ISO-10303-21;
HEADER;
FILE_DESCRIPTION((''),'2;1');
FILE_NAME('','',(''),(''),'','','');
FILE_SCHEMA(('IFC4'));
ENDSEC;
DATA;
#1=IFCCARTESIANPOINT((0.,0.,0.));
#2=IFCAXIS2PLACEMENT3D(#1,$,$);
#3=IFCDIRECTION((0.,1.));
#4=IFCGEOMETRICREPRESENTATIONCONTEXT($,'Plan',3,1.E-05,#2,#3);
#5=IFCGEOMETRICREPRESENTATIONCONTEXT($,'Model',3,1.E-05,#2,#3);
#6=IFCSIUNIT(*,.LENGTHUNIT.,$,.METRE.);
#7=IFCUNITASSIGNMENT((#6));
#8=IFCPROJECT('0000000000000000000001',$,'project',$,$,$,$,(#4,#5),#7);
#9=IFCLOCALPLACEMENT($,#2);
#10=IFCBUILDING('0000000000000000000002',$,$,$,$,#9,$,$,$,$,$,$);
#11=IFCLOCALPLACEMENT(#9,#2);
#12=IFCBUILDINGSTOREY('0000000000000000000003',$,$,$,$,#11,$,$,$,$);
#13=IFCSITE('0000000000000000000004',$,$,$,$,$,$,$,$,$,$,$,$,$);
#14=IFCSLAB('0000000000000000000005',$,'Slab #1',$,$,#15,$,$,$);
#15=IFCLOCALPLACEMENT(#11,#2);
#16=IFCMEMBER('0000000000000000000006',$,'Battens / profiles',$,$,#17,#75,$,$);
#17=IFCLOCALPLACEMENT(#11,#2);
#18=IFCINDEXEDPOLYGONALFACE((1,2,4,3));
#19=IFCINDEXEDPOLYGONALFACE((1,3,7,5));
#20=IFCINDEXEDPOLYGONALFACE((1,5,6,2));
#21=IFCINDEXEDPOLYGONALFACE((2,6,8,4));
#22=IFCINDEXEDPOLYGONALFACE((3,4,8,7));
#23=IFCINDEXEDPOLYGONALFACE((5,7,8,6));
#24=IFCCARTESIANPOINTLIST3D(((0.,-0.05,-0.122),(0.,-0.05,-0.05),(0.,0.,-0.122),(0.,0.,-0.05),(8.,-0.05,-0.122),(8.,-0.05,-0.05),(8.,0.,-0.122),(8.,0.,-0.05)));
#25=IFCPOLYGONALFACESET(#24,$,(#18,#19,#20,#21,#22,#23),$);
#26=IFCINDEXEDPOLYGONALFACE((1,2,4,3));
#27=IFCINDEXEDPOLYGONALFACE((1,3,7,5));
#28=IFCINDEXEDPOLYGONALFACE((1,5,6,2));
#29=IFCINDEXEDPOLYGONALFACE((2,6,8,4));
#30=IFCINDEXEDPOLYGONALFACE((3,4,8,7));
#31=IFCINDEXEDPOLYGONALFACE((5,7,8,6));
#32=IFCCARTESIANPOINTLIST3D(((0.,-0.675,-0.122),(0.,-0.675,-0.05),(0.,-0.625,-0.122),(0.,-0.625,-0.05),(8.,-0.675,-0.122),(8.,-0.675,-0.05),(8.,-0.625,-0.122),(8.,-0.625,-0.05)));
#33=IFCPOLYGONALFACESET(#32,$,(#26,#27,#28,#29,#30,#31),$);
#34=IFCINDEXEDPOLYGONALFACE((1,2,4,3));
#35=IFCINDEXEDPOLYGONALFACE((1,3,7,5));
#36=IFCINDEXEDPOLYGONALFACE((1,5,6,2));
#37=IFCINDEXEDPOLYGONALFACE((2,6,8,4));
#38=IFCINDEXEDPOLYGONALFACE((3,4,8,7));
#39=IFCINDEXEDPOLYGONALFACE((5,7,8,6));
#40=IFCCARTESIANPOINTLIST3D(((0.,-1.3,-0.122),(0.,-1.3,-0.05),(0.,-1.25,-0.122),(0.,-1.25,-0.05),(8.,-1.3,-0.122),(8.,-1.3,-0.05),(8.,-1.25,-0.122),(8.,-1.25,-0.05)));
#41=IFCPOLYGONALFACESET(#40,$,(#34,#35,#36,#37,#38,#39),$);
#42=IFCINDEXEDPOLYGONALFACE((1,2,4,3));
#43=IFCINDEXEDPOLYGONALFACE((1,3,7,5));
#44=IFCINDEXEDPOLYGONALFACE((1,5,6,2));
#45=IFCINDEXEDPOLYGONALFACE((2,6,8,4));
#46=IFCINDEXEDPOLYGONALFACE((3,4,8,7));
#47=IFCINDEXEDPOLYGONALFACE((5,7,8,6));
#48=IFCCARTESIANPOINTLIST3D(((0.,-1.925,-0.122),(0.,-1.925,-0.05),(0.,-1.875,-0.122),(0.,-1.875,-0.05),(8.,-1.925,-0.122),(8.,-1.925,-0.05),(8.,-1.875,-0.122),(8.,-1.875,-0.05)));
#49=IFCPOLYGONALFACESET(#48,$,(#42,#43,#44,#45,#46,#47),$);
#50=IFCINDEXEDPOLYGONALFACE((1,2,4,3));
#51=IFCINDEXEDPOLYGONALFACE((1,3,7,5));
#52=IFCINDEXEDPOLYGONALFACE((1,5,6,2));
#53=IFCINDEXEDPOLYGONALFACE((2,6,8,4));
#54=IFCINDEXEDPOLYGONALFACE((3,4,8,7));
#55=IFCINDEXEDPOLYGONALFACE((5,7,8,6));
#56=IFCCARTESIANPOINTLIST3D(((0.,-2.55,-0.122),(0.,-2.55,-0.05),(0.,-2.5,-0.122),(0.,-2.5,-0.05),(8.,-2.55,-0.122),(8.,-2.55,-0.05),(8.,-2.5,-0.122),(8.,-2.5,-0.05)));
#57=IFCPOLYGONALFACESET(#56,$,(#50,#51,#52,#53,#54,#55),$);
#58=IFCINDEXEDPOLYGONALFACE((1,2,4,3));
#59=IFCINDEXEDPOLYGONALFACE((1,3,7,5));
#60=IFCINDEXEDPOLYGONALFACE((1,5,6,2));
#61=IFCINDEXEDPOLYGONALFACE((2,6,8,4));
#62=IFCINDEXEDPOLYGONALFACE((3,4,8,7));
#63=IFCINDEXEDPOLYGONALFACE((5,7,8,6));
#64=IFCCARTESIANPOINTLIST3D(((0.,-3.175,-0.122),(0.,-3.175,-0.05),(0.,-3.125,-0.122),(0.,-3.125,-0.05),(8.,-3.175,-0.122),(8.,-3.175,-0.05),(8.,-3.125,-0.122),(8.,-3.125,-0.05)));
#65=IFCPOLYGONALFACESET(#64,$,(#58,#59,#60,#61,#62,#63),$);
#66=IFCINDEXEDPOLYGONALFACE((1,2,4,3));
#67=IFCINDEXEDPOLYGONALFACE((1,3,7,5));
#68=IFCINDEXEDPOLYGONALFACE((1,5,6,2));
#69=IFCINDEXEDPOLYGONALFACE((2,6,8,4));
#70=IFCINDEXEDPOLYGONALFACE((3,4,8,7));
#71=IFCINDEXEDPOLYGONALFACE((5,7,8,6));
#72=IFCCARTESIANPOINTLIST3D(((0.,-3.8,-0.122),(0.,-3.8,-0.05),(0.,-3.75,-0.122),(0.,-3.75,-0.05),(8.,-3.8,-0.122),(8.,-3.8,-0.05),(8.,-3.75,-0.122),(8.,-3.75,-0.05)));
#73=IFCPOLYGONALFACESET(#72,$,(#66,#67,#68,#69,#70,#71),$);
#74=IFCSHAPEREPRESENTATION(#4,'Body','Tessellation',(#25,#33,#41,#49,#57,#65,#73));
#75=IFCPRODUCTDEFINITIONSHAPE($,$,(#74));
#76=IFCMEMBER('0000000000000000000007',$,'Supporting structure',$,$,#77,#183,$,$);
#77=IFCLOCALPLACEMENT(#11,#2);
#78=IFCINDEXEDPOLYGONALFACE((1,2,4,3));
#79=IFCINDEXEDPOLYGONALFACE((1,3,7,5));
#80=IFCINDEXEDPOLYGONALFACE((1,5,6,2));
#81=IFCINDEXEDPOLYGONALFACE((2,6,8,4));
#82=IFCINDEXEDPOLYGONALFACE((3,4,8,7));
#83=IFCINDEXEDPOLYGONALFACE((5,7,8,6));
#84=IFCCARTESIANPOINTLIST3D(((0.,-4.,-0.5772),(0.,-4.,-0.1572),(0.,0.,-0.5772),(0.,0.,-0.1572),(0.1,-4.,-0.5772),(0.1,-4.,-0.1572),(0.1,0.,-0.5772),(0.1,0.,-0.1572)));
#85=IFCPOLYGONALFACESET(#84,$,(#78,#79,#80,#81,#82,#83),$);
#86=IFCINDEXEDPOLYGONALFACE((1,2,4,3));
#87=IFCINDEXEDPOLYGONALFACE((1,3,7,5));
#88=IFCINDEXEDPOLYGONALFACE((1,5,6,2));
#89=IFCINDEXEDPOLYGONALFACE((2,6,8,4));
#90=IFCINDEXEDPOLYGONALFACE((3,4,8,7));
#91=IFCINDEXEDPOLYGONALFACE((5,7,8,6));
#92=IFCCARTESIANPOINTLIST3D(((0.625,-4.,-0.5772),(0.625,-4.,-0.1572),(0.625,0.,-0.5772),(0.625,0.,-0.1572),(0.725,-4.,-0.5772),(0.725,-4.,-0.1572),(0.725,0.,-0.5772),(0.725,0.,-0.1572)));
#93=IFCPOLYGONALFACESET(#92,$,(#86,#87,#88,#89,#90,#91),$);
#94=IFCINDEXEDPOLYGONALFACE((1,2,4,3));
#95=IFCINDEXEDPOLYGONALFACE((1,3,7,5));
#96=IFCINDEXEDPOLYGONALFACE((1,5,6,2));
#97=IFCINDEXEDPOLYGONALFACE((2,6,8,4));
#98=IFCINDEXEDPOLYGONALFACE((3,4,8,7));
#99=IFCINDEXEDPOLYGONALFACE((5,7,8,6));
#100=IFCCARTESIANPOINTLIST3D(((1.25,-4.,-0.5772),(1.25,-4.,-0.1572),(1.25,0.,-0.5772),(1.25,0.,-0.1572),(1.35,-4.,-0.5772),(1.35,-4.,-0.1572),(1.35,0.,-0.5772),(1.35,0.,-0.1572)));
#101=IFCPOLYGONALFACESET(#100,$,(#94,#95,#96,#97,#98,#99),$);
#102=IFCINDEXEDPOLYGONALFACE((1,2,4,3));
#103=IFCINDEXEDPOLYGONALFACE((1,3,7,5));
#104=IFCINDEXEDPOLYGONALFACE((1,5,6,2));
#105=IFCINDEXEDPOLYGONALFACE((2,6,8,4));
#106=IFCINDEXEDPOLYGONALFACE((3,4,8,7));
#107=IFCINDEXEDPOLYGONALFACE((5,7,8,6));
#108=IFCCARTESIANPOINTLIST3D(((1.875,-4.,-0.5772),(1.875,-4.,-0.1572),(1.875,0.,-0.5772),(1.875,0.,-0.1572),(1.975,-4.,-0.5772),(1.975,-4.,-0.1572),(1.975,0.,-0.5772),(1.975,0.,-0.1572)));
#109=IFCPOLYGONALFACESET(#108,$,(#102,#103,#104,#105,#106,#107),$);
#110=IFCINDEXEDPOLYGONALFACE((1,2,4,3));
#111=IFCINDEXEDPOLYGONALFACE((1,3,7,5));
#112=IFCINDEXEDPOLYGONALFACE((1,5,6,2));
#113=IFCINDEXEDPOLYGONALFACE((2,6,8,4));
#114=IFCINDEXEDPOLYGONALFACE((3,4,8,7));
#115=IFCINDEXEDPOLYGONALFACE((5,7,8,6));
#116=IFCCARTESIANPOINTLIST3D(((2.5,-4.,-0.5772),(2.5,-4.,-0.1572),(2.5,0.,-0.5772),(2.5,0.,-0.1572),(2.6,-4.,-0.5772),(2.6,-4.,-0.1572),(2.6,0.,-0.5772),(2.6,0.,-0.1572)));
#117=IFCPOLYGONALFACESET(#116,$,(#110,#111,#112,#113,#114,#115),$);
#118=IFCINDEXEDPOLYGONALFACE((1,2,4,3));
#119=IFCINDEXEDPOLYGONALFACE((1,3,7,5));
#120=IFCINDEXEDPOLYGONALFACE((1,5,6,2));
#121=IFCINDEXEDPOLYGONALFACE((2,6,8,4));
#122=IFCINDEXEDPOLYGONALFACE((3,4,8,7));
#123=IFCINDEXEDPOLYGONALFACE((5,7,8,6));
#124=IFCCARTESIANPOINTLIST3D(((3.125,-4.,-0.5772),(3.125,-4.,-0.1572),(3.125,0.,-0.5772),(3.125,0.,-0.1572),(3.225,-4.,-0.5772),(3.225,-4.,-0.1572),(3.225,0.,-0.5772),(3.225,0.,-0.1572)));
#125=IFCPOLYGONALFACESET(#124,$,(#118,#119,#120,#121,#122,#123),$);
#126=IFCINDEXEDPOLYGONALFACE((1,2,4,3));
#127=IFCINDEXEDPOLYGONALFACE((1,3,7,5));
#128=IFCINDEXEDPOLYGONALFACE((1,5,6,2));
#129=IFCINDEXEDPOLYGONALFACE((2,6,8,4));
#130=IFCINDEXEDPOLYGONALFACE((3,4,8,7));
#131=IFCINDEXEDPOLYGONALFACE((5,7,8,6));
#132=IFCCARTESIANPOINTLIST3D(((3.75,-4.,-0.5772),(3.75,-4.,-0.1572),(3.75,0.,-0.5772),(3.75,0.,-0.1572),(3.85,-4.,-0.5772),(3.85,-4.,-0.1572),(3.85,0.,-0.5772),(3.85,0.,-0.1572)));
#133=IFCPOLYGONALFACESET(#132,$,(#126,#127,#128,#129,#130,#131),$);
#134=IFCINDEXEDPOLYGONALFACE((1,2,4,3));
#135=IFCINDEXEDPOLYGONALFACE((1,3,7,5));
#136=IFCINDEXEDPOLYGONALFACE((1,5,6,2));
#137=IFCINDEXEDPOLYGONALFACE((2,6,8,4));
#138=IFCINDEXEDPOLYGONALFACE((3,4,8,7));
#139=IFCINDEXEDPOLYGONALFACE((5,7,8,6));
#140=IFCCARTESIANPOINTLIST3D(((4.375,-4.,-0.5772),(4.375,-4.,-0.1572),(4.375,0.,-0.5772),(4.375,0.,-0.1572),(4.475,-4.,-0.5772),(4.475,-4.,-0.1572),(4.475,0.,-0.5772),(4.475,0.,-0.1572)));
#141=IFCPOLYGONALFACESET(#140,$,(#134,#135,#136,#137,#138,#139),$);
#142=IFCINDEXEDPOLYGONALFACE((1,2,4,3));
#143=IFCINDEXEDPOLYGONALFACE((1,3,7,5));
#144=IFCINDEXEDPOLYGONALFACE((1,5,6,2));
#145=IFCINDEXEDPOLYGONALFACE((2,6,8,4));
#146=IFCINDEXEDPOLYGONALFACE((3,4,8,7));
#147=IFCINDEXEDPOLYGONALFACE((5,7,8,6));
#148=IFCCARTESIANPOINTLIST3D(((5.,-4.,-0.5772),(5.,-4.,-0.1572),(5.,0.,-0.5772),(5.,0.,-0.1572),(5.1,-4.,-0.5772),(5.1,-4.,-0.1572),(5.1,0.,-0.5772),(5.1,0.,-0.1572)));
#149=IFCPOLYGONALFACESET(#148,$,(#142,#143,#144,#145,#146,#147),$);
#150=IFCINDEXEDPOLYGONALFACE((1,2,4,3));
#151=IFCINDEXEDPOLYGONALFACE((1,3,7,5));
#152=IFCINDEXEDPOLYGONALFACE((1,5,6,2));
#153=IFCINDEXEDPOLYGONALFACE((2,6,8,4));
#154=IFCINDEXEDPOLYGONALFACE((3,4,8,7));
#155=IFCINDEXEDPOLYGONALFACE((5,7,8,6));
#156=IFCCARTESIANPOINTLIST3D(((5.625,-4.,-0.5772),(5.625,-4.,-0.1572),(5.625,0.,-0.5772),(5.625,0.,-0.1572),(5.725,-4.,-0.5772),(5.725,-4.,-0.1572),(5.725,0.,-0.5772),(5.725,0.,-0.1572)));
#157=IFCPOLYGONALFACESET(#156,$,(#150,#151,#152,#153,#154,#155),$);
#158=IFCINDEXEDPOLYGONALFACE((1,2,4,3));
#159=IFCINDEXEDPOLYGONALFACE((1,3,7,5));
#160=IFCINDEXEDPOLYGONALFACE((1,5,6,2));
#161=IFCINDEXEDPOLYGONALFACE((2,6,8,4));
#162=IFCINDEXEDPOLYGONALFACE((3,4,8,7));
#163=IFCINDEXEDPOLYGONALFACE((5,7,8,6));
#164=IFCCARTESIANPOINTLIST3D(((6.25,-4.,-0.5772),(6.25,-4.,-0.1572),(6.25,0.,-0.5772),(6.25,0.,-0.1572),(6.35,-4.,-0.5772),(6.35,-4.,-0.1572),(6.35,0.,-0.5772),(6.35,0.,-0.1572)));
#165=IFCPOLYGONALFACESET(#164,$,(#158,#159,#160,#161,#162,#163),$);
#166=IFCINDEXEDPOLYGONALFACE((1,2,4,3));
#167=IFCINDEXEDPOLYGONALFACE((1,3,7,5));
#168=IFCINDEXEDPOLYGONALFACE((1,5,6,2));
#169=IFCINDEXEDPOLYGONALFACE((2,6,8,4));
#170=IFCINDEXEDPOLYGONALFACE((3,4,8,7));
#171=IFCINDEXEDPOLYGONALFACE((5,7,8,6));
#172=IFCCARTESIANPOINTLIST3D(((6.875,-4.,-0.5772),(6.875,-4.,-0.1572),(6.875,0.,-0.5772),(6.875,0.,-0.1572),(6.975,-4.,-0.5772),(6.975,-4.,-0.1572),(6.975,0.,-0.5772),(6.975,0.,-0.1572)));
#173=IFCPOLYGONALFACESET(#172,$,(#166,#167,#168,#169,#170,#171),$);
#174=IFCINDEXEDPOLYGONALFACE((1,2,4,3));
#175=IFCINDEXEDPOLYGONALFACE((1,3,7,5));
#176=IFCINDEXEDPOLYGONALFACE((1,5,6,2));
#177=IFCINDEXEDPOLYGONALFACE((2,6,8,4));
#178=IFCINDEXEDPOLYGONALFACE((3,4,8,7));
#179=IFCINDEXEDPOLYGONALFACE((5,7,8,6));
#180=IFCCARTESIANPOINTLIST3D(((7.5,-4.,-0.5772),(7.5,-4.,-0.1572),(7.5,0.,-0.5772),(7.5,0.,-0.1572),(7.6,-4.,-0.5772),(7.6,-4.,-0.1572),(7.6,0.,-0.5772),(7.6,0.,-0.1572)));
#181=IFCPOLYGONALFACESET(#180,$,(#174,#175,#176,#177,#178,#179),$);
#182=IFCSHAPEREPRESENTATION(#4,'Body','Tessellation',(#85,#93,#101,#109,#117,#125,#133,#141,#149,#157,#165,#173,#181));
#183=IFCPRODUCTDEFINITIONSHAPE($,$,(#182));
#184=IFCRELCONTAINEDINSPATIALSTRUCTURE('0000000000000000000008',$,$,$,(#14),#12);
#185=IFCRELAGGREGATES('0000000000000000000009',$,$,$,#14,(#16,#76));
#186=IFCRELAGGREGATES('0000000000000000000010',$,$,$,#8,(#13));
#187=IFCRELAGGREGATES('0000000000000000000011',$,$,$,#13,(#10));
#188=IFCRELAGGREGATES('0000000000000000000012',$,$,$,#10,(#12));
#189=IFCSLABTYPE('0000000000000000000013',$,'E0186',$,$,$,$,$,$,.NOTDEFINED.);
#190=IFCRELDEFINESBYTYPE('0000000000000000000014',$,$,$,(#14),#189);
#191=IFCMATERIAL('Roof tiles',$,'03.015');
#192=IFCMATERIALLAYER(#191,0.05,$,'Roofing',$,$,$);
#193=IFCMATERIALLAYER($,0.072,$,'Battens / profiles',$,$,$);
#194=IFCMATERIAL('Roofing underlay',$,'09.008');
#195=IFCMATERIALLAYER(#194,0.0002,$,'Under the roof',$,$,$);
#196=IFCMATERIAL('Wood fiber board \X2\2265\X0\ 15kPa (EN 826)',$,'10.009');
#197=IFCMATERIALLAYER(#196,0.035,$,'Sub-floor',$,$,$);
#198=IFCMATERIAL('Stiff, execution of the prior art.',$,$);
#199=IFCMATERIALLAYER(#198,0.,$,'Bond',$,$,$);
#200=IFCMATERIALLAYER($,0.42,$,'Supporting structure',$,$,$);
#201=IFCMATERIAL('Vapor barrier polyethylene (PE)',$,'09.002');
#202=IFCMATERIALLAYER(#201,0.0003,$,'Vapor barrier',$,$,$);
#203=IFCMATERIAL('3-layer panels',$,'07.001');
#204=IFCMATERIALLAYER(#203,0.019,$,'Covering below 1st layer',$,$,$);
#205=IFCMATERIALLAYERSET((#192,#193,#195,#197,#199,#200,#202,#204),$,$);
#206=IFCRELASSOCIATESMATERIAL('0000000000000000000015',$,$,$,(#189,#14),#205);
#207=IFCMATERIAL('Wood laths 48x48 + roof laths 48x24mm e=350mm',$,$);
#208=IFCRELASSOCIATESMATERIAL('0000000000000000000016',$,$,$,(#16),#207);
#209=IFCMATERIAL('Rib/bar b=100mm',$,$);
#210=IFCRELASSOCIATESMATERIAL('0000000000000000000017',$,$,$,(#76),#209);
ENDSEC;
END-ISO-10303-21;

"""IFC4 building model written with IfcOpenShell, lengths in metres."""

from ifc_helpers import new_model, si_unit, direction, frame, frame_2d, origin, place, context, project, spatial, rectangle, extrude, material, layer, layer_set, type_object, element, aggregate, save


model = new_model("IFC4")

# Units and contexts
plan_context = context("Plan", 3, precision=1e-05, world=origin(), true_north=direction((0.0, 1.0)))
model_context = context("Model", 3, precision=1e-05, world=origin(), true_north=direction((0.0, 1.0)))
ifc_project = project(units=[si_unit("LENGTHUNIT", "METRE")], contexts=[plan_context, model_context])

# Site, building, storey
site = spatial("IfcSite", under=ifc_project)
building_placement = place(None, origin())
building = spatial("IfcBuilding", under=site, at=building_placement)
storey_placement = place(building_placement, origin())
storey = spatial("IfcBuildingStorey", under=building, at=storey_placement)

# Slab, members
ifc_material_1 = material(Name="Roof tiles", Category="03.015")
ifc_layer_1 = layer(ifc_material_1, 0.05, Name="Roofing")
ifc_layer_2 = layer(None, 0.072, Name="Battens / profiles")
ifc_material_2 = material(Name="Roofing underlay", Category="09.008")
ifc_layer_3 = layer(ifc_material_2, 0.0002, Name="Under the roof")
ifc_material_3 = material(Name="Wood fiber board ≥ 15kPa (EN 826)", Category="10.009")
ifc_layer_4 = layer(ifc_material_3, 0.035, Name="Sub-floor")
ifc_material_4 = material(Name="Stiff, execution of the prior art.")
ifc_layer_5 = layer(ifc_material_4, 0.0, Name="Bond")
ifc_layer_6 = layer(None, 0.42, Name="Supporting structure")
ifc_material_5 = material(Name="Vapor barrier polyethylene (PE)", Category="09.002")
ifc_layer_7 = layer(ifc_material_5, 0.0003, Name="Vapor barrier")
ifc_material_6 = material(Name="3-layer panels", Category="07.001")
ifc_layer_8 = layer(ifc_material_6, 0.019, Name="Covering below 1st layer")
ifc_layer_set = layer_set([ifc_layer_1, ifc_layer_2, ifc_layer_3, ifc_layer_4, ifc_layer_5, ifc_layer_6, ifc_layer_7, ifc_layer_8])
slab_type = type_object("IfcSlabType", Name="E0186", PredefinedType="NOTDEFINED", material=ifc_layer_set)
slab_placement = place(None, frame((0.0, 0.0, 0.0), z_axis=(0.0, 0.0, -1.0), x_axis=(1.0, 0.0, 0.0)))
slab = element("IfcSlab", 1, at=slab_placement, inside=storey, type_object=slab_type, material=ifc_layer_set, Name="Slab #1")
ifc_material_7 = material(Name="Wood laths 48x48 + roof laths 48x24mm e=350mm")
member_1_placement = place(slab_placement, origin())
member_1 = element("IfcMember", 2, at=member_1_placement, material=ifc_material_7, Name="Battens / profiles", context=plan_context, shape_type="SweptSolid", body=[
    extrude(rectangle(XDim=0.05, YDim=0.072, at=frame_2d((0.025, 0.036), x_axis=(1.0, 0.0))), frame((0.0, 0.0, 0.05), z_axis=(1.0, 0.0, 0.0), x_axis=(0.0, 1.0, 0.0)), (0.0, 0.0, 1.0), 8.0),
    extrude(rectangle(XDim=0.05, YDim=0.072, at=frame_2d((0.025, 0.036), x_axis=(1.0, 0.0))), frame((0.0, 0.625, 0.05), z_axis=(1.0, 0.0, 0.0), x_axis=(0.0, 1.0, 0.0)), (0.0, 0.0, 1.0), 8.0),
    extrude(rectangle(XDim=0.05, YDim=0.072, at=frame_2d((0.025, 0.036), x_axis=(1.0, 0.0))), frame((0.0, 1.25, 0.05), z_axis=(1.0, 0.0, 0.0), x_axis=(0.0, 1.0, 0.0)), (0.0, 0.0, 1.0), 8.0),
    extrude(rectangle(XDim=0.05, YDim=0.072, at=frame_2d((0.025, 0.036), x_axis=(1.0, 0.0))), frame((0.0, 1.875, 0.05), z_axis=(1.0, 0.0, 0.0), x_axis=(0.0, 1.0, 0.0)), (0.0, 0.0, 1.0), 8.0),
    extrude(rectangle(XDim=0.05, YDim=0.072, at=frame_2d((0.025, 0.036), x_axis=(1.0, 0.0))), frame((0.0, 2.5, 0.05), z_axis=(1.0, 0.0, 0.0), x_axis=(0.0, 1.0, 0.0)), (0.0, 0.0, 1.0), 8.0),
    extrude(rectangle(XDim=0.05, YDim=0.072, at=frame_2d((0.025, 0.036), x_axis=(1.0, 0.0))), frame((0.0, 3.125, 0.05), z_axis=(1.0, 0.0, 0.0), x_axis=(0.0, 1.0, 0.0)), (0.0, 0.0, 1.0), 8.0),
    extrude(rectangle(XDim=0.05, YDim=0.072, at=frame_2d((0.025, 0.036), x_axis=(1.0, 0.0))), frame((0.0, 3.75, 0.05), z_axis=(1.0, 0.0, 0.0), x_axis=(0.0, 1.0, 0.0)), (0.0, 0.0, 1.0), 8.0),
])
ifc_material_8 = material(Name="Rib/bar b=100mm")
member_2_placement = place(slab_placement, origin())
member_2 = element("IfcMember", 3, at=member_2_placement, material=ifc_material_8, Name="Supporting structure", context=plan_context, shape_type="SweptSolid", body=[
    extrude(rectangle(XDim=0.1, YDim=0.42, at=frame_2d((0.05, 0.21), x_axis=(1.0, 0.0))), frame((0.0, 4.0, 0.1572), z_axis=(0.0, -1.0, 0.0), x_axis=(1.0, 0.0, 0.0)), (0.0, 0.0, 1.0), 4.0),
    extrude(rectangle(XDim=0.1, YDim=0.42, at=frame_2d((0.05, 0.21), x_axis=(1.0, 0.0))), frame((0.625, 4.0, 0.1572), z_axis=(0.0, -1.0, 0.0), x_axis=(1.0, 0.0, 0.0)), (0.0, 0.0, 1.0), 4.0),
    extrude(rectangle(XDim=0.1, YDim=0.42, at=frame_2d((0.05, 0.21), x_axis=(1.0, 0.0))), frame((1.25, 4.0, 0.1572), z_axis=(0.0, -1.0, 0.0), x_axis=(1.0, 0.0, 0.0)), (0.0, 0.0, 1.0), 4.0),
    extrude(rectangle(XDim=0.1, YDim=0.42, at=frame_2d((0.05, 0.21), x_axis=(1.0, 0.0))), frame((1.875, 4.0, 0.1572), z_axis=(0.0, -1.0, 0.0), x_axis=(1.0, 0.0, 0.0)), (0.0, 0.0, 1.0), 4.0),
    extrude(rectangle(XDim=0.1, YDim=0.42, at=frame_2d((0.05, 0.21), x_axis=(1.0, 0.0))), frame((2.5, 4.0, 0.1572), z_axis=(0.0, -1.0, 0.0), x_axis=(1.0, 0.0, 0.0)), (0.0, 0.0, 1.0), 4.0),
    extrude(rectangle(XDim=0.1, YDim=0.42, at=frame_2d((0.05, 0.21), x_axis=(1.0, 0.0))), frame((3.125, 4.0, 0.1572), z_axis=(0.0, -1.0, 0.0), x_axis=(1.0, 0.0, 0.0)), (0.0, 0.0, 1.0), 4.0),
    extrude(rectangle(XDim=0.1, YDim=0.42, at=frame_2d((0.05, 0.21), x_axis=(1.0, 0.0))), frame((3.75, 4.0, 0.1572), z_axis=(0.0, -1.0, 0.0), x_axis=(1.0, 0.0, 0.0)), (0.0, 0.0, 1.0), 4.0),
    extrude(rectangle(XDim=0.1, YDim=0.42, at=frame_2d((0.05, 0.21), x_axis=(1.0, 0.0))), frame((4.375, 4.0, 0.1572), z_axis=(0.0, -1.0, 0.0), x_axis=(1.0, 0.0, 0.0)), (0.0, 0.0, 1.0), 4.0),
    extrude(rectangle(XDim=0.1, YDim=0.42, at=frame_2d((0.05, 0.21), x_axis=(1.0, 0.0))), frame((5.0, 4.0, 0.1572), z_axis=(0.0, -1.0, 0.0), x_axis=(1.0, 0.0, 0.0)), (0.0, 0.0, 1.0), 4.0),
    extrude(rectangle(XDim=0.1, YDim=0.42, at=frame_2d((0.05, 0.21), x_axis=(1.0, 0.0))), frame((5.625, 4.0, 0.1572), z_axis=(0.0, -1.0, 0.0), x_axis=(1.0, 0.0, 0.0)), (0.0, 0.0, 1.0), 4.0),
    extrude(rectangle(XDim=0.1, YDim=0.42, at=frame_2d((0.05, 0.21), x_axis=(1.0, 0.0))), frame((6.25, 4.0, 0.1572), z_axis=(0.0, -1.0, 0.0), x_axis=(1.0, 0.0, 0.0)), (0.0, 0.0, 1.0), 4.0),
    extrude(rectangle(XDim=0.1, YDim=0.42, at=frame_2d((0.05, 0.21), x_axis=(1.0, 0.0))), frame((6.875, 4.0, 0.1572), z_axis=(0.0, -1.0, 0.0), x_axis=(1.0, 0.0, 0.0)), (0.0, 0.0, 1.0), 4.0),
    extrude(rectangle(XDim=0.1, YDim=0.42, at=frame_2d((0.05, 0.21), x_axis=(1.0, 0.0))), frame((7.5, 4.0, 0.1572), z_axis=(0.0, -1.0, 0.0), x_axis=(1.0, 0.0, 0.0)), (0.0, 0.0, 1.0), 4.0),
])
aggregate(slab, [member_1, member_2])

save(model, "model.ifc")
